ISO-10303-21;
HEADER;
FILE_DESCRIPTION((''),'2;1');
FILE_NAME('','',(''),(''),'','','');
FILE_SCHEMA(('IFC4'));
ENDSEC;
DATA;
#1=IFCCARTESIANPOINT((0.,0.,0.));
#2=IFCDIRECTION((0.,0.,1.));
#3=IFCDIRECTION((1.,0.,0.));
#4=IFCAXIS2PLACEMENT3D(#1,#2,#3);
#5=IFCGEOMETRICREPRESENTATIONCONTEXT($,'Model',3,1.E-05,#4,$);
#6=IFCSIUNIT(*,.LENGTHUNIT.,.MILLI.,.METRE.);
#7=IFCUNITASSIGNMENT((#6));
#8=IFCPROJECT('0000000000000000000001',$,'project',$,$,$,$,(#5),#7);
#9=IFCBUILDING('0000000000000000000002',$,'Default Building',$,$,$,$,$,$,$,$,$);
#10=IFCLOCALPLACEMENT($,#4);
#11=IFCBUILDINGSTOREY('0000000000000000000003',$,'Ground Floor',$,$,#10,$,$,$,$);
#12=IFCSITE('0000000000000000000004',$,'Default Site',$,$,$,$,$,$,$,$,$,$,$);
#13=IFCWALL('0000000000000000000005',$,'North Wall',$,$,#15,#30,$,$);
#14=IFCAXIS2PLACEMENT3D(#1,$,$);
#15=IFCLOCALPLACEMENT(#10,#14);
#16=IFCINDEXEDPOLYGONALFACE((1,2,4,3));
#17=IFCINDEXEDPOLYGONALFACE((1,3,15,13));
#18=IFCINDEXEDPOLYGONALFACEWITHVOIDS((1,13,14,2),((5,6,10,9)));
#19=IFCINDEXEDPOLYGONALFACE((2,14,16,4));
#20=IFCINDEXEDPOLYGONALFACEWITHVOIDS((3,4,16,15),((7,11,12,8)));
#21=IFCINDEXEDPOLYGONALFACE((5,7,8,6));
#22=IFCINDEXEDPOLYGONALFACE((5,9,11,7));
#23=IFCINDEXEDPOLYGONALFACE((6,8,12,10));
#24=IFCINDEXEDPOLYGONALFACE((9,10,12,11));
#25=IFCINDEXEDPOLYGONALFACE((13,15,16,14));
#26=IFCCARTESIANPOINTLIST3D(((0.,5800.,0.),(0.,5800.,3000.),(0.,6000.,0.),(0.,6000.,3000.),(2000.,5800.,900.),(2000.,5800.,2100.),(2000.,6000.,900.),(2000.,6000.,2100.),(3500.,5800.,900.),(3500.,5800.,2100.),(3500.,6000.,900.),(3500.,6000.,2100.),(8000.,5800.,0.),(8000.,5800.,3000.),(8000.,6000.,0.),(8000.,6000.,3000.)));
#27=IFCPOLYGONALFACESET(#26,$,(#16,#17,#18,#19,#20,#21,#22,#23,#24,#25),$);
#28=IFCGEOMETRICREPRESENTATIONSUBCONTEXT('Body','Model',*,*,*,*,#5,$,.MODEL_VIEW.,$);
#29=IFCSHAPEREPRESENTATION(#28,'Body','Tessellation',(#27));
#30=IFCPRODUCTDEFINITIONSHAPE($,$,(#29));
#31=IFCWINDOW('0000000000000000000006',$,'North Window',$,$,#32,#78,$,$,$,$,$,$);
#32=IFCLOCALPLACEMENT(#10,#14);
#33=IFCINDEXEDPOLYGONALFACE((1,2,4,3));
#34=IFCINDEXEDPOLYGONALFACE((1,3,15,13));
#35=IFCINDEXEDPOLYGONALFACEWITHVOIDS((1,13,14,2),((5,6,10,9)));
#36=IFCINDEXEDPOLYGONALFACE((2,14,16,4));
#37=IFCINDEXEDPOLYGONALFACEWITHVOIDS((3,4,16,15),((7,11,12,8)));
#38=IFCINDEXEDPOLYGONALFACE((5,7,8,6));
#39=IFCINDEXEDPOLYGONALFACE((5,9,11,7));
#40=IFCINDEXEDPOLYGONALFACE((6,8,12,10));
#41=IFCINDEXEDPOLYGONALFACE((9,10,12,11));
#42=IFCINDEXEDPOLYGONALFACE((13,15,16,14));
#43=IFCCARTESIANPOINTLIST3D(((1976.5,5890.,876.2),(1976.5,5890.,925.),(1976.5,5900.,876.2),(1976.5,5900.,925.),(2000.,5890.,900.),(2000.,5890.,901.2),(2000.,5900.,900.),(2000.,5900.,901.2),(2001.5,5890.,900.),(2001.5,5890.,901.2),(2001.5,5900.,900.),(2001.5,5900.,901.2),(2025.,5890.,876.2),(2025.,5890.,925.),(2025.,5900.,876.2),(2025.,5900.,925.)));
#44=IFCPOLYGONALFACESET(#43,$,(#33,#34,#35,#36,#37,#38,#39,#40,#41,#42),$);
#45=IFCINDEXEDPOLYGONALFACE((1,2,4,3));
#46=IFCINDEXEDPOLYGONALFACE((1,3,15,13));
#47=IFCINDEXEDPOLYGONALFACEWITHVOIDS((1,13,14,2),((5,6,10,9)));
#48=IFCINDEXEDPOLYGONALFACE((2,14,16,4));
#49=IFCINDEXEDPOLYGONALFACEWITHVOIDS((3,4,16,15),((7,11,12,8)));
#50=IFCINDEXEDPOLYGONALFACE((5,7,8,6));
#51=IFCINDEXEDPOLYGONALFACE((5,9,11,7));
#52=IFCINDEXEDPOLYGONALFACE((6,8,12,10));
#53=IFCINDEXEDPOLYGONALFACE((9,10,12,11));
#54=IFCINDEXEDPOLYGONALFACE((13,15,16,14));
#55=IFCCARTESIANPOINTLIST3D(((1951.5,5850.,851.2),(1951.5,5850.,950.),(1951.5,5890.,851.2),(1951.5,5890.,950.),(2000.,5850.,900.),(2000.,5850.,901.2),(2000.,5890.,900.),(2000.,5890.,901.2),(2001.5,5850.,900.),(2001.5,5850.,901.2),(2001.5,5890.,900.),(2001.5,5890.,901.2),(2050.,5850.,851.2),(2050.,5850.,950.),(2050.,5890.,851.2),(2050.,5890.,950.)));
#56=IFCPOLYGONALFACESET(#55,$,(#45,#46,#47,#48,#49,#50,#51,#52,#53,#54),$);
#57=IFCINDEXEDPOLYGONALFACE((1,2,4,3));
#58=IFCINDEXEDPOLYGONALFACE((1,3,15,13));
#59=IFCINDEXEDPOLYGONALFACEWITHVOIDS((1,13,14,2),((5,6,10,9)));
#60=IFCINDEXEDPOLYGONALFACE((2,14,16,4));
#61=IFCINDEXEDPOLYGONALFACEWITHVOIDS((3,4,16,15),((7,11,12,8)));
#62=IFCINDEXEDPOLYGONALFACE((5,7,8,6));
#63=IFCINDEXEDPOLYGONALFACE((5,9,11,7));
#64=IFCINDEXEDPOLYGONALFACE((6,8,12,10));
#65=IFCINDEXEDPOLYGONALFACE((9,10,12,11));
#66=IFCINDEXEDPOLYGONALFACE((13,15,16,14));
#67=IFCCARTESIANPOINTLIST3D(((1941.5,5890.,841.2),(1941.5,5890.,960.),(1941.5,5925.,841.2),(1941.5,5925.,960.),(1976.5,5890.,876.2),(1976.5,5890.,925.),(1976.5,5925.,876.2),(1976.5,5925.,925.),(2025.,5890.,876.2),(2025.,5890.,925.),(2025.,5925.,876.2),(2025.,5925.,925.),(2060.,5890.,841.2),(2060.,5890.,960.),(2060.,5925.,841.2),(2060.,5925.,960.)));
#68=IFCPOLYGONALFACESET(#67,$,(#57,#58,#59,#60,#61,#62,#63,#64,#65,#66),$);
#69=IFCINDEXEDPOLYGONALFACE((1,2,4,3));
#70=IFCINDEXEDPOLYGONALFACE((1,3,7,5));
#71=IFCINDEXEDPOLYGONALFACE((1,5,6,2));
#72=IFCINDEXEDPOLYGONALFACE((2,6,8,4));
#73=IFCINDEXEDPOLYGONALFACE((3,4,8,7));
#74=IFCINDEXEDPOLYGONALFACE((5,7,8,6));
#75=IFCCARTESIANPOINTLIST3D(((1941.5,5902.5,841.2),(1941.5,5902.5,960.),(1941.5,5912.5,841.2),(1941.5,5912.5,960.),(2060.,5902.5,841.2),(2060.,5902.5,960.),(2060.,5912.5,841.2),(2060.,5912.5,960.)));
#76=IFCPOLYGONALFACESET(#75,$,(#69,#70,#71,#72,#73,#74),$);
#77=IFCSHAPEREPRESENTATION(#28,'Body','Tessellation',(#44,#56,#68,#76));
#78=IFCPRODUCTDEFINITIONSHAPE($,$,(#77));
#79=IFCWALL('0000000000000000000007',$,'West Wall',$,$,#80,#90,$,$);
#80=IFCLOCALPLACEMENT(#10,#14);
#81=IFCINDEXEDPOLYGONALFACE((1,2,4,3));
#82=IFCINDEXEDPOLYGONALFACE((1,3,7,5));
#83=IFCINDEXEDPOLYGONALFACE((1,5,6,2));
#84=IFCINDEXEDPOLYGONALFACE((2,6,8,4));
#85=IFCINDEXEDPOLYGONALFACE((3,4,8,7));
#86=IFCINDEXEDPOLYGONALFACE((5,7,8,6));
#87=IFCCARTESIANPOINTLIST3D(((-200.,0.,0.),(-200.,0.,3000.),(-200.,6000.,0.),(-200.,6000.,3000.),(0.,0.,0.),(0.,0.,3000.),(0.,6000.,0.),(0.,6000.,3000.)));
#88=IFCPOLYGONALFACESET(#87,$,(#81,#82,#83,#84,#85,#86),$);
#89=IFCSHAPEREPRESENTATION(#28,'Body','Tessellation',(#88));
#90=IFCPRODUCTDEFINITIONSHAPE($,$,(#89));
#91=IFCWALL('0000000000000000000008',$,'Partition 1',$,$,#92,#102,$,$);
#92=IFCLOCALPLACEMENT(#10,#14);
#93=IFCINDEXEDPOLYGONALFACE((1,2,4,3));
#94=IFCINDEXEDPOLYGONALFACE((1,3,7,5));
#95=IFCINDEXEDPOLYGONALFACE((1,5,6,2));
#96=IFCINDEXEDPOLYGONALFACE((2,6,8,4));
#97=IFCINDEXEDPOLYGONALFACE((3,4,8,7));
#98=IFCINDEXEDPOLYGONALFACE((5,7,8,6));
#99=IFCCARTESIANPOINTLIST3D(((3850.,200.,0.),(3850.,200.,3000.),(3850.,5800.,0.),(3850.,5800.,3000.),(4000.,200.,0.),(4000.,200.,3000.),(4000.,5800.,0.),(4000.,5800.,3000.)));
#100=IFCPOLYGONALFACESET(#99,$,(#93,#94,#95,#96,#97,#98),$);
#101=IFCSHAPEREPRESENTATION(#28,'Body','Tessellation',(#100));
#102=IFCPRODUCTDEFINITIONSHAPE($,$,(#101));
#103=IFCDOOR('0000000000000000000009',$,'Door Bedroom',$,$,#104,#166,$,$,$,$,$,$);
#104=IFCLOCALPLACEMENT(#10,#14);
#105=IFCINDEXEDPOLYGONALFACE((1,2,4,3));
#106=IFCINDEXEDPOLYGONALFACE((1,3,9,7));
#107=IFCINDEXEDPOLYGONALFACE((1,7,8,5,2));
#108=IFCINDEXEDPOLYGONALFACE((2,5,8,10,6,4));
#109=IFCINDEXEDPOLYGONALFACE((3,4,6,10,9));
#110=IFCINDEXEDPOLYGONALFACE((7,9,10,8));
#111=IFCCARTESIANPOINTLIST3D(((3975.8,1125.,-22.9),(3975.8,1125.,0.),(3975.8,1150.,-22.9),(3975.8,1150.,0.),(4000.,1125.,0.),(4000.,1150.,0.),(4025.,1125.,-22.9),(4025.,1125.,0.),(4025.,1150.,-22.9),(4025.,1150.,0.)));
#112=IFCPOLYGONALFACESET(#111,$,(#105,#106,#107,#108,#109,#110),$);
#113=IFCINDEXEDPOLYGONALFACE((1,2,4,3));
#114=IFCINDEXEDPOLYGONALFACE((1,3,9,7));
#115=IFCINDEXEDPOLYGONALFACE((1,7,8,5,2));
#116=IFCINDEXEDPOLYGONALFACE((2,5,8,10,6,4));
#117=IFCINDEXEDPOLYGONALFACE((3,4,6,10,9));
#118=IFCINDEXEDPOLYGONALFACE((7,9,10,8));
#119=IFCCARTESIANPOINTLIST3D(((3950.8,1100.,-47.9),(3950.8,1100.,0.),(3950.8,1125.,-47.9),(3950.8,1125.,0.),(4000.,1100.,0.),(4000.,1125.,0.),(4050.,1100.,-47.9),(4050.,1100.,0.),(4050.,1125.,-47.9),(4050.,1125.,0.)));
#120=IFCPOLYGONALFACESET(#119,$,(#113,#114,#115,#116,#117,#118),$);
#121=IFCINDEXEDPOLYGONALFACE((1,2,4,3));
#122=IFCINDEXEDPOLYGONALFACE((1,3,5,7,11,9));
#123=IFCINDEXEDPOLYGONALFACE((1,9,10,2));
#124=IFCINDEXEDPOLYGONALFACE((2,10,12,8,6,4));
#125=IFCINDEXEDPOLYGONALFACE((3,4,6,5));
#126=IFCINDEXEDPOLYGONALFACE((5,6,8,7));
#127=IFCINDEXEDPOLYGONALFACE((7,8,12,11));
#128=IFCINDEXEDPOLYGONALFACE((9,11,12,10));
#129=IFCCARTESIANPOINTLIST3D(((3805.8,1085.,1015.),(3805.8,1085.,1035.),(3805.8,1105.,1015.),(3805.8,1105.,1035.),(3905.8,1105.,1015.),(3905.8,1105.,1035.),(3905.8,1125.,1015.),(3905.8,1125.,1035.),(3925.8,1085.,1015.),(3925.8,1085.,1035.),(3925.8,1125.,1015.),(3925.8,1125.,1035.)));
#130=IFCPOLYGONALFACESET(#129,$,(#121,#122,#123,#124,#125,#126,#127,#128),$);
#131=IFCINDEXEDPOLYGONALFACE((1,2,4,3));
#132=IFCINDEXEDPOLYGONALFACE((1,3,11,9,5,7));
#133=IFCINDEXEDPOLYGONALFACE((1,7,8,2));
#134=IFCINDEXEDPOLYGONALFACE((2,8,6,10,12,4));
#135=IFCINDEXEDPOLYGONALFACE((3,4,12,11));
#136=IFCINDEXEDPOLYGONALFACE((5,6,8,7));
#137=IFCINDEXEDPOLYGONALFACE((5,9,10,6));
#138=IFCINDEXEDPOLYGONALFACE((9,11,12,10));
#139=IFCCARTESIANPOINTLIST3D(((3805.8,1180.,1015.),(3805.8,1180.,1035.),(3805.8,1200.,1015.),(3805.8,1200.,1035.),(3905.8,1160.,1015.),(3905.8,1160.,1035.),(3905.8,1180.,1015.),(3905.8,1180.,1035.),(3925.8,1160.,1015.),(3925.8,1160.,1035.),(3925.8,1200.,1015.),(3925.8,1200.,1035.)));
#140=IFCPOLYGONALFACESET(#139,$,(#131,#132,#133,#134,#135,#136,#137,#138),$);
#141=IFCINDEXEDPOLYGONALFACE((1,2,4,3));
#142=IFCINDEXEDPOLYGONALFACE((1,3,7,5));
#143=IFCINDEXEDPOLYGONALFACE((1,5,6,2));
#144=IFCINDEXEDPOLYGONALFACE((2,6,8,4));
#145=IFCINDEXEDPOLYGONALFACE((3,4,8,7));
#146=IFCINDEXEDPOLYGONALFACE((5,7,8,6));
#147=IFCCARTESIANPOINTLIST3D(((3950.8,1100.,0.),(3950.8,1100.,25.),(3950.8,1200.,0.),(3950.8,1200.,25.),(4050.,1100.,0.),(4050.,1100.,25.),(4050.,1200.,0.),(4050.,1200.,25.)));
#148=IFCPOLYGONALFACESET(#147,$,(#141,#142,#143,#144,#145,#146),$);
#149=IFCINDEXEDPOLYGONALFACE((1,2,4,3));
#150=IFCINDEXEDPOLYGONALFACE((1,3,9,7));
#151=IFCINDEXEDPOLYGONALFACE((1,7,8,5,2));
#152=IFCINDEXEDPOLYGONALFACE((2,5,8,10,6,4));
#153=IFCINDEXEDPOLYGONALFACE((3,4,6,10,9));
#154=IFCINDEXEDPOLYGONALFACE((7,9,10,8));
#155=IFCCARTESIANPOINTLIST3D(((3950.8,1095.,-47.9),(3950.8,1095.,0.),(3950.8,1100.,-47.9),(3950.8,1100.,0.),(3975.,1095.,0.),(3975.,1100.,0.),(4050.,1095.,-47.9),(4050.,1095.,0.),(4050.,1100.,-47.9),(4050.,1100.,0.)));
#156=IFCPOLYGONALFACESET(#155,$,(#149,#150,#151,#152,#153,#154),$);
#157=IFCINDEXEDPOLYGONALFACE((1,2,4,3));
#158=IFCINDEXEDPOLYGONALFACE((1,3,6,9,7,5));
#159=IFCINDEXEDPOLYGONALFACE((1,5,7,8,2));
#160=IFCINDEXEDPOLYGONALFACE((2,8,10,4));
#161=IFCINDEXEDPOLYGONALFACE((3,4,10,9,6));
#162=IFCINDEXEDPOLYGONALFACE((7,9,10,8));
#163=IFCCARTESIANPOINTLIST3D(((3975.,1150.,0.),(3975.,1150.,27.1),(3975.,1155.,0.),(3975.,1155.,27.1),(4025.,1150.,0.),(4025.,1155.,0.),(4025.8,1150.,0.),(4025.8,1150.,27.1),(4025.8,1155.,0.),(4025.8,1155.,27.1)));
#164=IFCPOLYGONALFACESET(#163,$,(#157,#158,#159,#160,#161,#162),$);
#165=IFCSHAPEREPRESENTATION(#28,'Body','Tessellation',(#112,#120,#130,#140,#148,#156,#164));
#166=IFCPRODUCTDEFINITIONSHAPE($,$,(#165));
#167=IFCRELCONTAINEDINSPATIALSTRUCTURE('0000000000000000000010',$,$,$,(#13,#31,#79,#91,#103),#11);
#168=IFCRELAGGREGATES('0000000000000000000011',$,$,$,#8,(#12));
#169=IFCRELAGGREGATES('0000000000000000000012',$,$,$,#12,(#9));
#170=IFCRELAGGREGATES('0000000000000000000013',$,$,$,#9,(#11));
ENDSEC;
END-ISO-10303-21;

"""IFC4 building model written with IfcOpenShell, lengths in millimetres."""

from ifc_helpers import new_model, si_unit, frame, origin_with_axes, place, context, subcontext, project, spatial, line, indexed_curve, outline, extrude, element, fill, save


model = new_model("IFC4")

# Units and contexts
model_context = context("Model", 3, precision=1e-05, world=origin_with_axes())
body_context = subcontext(model_context, "Body", "Model", "MODEL_VIEW")
ifc_project = project(units=[si_unit("LENGTHUNIT", "METRE", prefix="MILLI")], contexts=[model_context])

# Site, building, storey
site = spatial("IfcSite", under=ifc_project, Name="Default Site")
building = spatial("IfcBuilding", under=site, Name="Default Building")
storey_placement = place(None, origin_with_axes())
storey = spatial("IfcBuildingStorey", under=building, at=storey_placement, Name="Ground Floor")

# Wall, opening, window
wall_1_placement = place(storey_placement, origin_with_axes())
wall_1 = element("IfcWall", 1, at=wall_1_placement, inside=storey, Name="North Wall", context=body_context, shape_type="SweptSolid", body=[
    extrude(outline(indexed_curve([(0.0, 5800.0), (8000.0, 5800.0), (8000.0, 6000.0), (0.0, 6000.0), (0.0, 5800.0)])), None, (0.0, 0.0, 1.0), 3000.0),
])
opening_1_placement = place(wall_1_placement, frame((0.0, 0.0, 900.0), z_axis=(0.0, 0.0, 1.0), x_axis=(1.0, 0.0, 0.0)))
opening_1 = element("IfcOpeningElement", 2, at=opening_1_placement, cuts=wall_1, context=body_context, shape_type="SweptSolid", body=[
    extrude(outline(indexed_curve([(2000.0, 5800.0), (3500.0, 5800.0), (3500.0, 6000.0), (2000.0, 6000.0), (2000.0, 5800.0)])), None, (0.0, 0.0, 1.0), 1200.0),
])
window_1_placement = place(storey_placement, frame((2000.0, 5800.0, 900.0), z_axis=(0.0, 0.0, 1.0), x_axis=(1.0, 0.0, 0.0)))
window_1 = element("IfcWindow", 3, at=window_1_placement, inside=storey, Name="North Window", context=body_context, shape_type="SweptSolid", body=[
    extrude(outline(indexed_curve([(0.0, 0.0), (1.5, 0.0), (1.5, 1.2), (0.0, 1.2)], segments=[line(1, 2, 3, 4, 1)]), holes=[indexed_curve([(25.0, 25.0), (-23.5, 25.0), (-23.5, -23.8), (25.0, -23.8)], segments=[line(1, 2, 3, 4, 1)])]), frame((0.0, 90.0, 0.0), z_axis=(0.0, -1.0, 0.0), x_axis=(1.0, 0.0, 0.0)), (0.0, 0.0, -1.0), 10.0),
    extrude(outline(indexed_curve([(0.0, 0.0), (1.5, 0.0), (1.5, 1.2), (0.0, 1.2)], segments=[line(1, 2, 3, 4, 1)]), holes=[indexed_curve([(50.0, 50.0), (-48.5, 50.0), (-48.5, -48.8), (50.0, -48.8)], segments=[line(1, 2, 3, 4, 1)])]), frame((0.0, 50.0, 0.0), z_axis=(0.0, -1.0, 0.0), x_axis=(1.0, 0.0, 0.0)), (0.0, 0.0, -1.0), 40.0),
    extrude(outline(indexed_curve([(0.0, 0.0), (-48.5, 0.0), (-48.5, -48.8), (0.0, -48.8)], segments=[line(1, 2, 3, 4, 1)]), holes=[indexed_curve([(35.0, 35.0), (-83.5, 35.0), (-83.5, -83.8), (35.0, -83.8)], segments=[line(1, 2, 3, 4, 1)])]), frame((25.0, 90.0, 25.0), z_axis=(0.0, -1.0, 0.0), x_axis=(1.0, 0.0, 0.0)), (0.0, 0.0, -1.0), 35.0),
    extrude(outline(indexed_curve([(35.0, 35.0), (-83.5, 35.0), (-83.5, -83.8), (35.0, -83.8)], segments=[line(1, 2, 3, 4, 1)])), frame((25.0, 102.5, 25.0), z_axis=(0.0, -1.0, 0.0), x_axis=(1.0, 0.0, 0.0)), (0.0, 0.0, -1.0), 10.0),
])
fill(opening_1, window_1)

# Wall
wall_2_placement = place(storey_placement, origin_with_axes())
element("IfcWall", 4, at=wall_2_placement, inside=storey, Name="West Wall", context=body_context, shape_type="SweptSolid", body=[
    extrude(outline(indexed_curve([(0.0, 0.0), (0.0, 6000.0), (-200.0, 6000.0), (-200.0, 0.0), (0.0, 0.0)])), None, (0.0, 0.0, 1.0), 3000.0),
])

# Wall, opening, door
wall_3_placement = place(storey_placement, origin_with_axes())
wall_3 = element("IfcWall", 5, at=wall_3_placement, inside=storey, Name="Partition 1", context=body_context, shape_type="SweptSolid", body=[
    extrude(outline(indexed_curve([(4000.0, 200.0), (4000.0, 5800.0), (3850.0, 5800.0), (3850.0, 200.0), (4000.0, 200.0)])), None, (0.0, 0.0, 1.0), 3000.0),
])
opening_2_placement = place(wall_3_placement, origin_with_axes())
opening_2 = element("IfcOpeningElement", 6, at=opening_2_placement, cuts=wall_3, context=body_context, shape_type="SweptSolid", body=[
    extrude(outline(indexed_curve([(4000.0, 1100.0), (4800.0, 1100.0), (4800.0, 1250.0), (4000.0, 1250.0), (4000.0, 1100.0)])), None, (0.0, 0.0, 1.0), 2100.0),
])
door_1_placement = place(storey_placement, frame((4000.0, 1100.0, 0.0), z_axis=(0.0, 0.0, 1.0), x_axis=(1.0, 0.0, 0.0)))
door_1 = element("IfcDoor", 7, at=door_1_placement, inside=storey, Name="Door Bedroom", context=body_context, shape_type="SweptSolid", body=[
    extrude(outline(indexed_curve([(0.0, 0.0), (0.0, 2.1), (0.8, 2.1), (0.8, 0.0), (-24.2, 0.0), (-24.2, -22.9), (25.0, -22.9), (25.0, 0.0)], segments=[line(1, 2, 3, 4, 5, 6, 7, 8, 1)])), frame((0.0, 25.0, 0.0), z_axis=(0.0, -1.0, 0.0), x_axis=(1.0, 0.0, 0.0)), (0.0, 0.0, -1.0), 25.0),
    extrude(outline(indexed_curve([(0.0, 0.0), (0.0, 2.1), (0.8, 2.1), (0.8, 0.0), (-49.2, 0.0), (-49.2, -47.9), (50.0, -47.9), (50.0, 0.0)], segments=[line(1, 2, 3, 4, 5, 6, 7, 8, 1)])), frame((0.0, 0.0, 0.0), z_axis=(0.0, -1.0, 0.0), x_axis=(1.0, 0.0, 0.0)), (0.0, 0.0, -1.0), 25.0),
    extrude(outline(indexed_curve([(0.0, 0.0), (-49.2, 0.0), (-49.2, 35.0), (0.0, 35.0)], segments=[line(1, 2, 3, 4, 1)])), frame((25.0, 25.0, 25.0), z_axis=(0.0, 0.0, 1.0), x_axis=(1.0, 0.0, 0.0)), (0.0, 0.0, 1.0), -47.9),
    extrude(outline(indexed_curve([(0.0, 0.0), (0.0, -40.0), (-120.0, -40.0), (-120.0, -20.0), (-20.0, -20.0), (-20.0, 0.0)], segments=[line(1, 2, 3, 4, 5, 6, 1)])), frame((-74.2, 25.0, 1015.0), z_axis=(0.0, 0.0, 1.0), x_axis=(1.0, 0.0, 0.0)), (0.0, 0.0, 1.0), 20.0),
    extrude(outline(indexed_curve([(0.0, 0.0), (0.0, 40.0), (-120.0, 40.0), (-120.0, 20.0), (-20.0, 20.0), (-20.0, 0.0)], segments=[line(1, 2, 3, 4, 5, 6, 1)])), frame((-74.2, 60.0, 1015.0), z_axis=(0.0, 0.0, 1.0), x_axis=(1.0, 0.0, 0.0)), (0.0, 0.0, 1.0), 20.0),
    extrude(outline(indexed_curve([(0.0, 0.0), (-99.2, 0.0), (-99.2, 100.0), (0.0, 100.0)], segments=[line(1, 2, 3, 4, 1)])), frame((50.0, 0.0, 0.0), z_axis=(0.0, 0.0, 1.0), x_axis=(1.0, 0.0, 0.0)), (0.0, 0.0, 1.0), 25.0),
    extrude(outline(indexed_curve([(0.0, 0.0), (0.0, 27.1), (50.8, 27.1), (50.8, 0.0), (-24.2, 0.0), (-24.2, -47.9), (75.0, -47.9), (75.0, 0.0)], segments=[line(1, 2, 3, 4, 5, 6, 7, 8, 1)])), frame((-25.0, -5.0, 0.0), z_axis=(0.0, -1.0, 0.0), x_axis=(1.0, 0.0, 0.0)), (0.0, 0.0, -1.0), 5.0),
    extrude(outline(indexed_curve([(0.0, 0.0), (0.0, 27.1), (50.8, 27.1), (50.8, 0.0), (0.8, 0.0), (0.8, -22.9), (50.0, -22.9), (50.0, 0.0)], segments=[line(1, 2, 3, 4, 5, 6, 7, 8, 1)])), frame((-25.0, 50.0, 0.0), z_axis=(0.0, -1.0, 0.0), x_axis=(1.0, 0.0, 0.0)), (0.0, 0.0, -1.0), 5.0),
])
fill(opening_2, door_1)

save(model, "model.ifc")
